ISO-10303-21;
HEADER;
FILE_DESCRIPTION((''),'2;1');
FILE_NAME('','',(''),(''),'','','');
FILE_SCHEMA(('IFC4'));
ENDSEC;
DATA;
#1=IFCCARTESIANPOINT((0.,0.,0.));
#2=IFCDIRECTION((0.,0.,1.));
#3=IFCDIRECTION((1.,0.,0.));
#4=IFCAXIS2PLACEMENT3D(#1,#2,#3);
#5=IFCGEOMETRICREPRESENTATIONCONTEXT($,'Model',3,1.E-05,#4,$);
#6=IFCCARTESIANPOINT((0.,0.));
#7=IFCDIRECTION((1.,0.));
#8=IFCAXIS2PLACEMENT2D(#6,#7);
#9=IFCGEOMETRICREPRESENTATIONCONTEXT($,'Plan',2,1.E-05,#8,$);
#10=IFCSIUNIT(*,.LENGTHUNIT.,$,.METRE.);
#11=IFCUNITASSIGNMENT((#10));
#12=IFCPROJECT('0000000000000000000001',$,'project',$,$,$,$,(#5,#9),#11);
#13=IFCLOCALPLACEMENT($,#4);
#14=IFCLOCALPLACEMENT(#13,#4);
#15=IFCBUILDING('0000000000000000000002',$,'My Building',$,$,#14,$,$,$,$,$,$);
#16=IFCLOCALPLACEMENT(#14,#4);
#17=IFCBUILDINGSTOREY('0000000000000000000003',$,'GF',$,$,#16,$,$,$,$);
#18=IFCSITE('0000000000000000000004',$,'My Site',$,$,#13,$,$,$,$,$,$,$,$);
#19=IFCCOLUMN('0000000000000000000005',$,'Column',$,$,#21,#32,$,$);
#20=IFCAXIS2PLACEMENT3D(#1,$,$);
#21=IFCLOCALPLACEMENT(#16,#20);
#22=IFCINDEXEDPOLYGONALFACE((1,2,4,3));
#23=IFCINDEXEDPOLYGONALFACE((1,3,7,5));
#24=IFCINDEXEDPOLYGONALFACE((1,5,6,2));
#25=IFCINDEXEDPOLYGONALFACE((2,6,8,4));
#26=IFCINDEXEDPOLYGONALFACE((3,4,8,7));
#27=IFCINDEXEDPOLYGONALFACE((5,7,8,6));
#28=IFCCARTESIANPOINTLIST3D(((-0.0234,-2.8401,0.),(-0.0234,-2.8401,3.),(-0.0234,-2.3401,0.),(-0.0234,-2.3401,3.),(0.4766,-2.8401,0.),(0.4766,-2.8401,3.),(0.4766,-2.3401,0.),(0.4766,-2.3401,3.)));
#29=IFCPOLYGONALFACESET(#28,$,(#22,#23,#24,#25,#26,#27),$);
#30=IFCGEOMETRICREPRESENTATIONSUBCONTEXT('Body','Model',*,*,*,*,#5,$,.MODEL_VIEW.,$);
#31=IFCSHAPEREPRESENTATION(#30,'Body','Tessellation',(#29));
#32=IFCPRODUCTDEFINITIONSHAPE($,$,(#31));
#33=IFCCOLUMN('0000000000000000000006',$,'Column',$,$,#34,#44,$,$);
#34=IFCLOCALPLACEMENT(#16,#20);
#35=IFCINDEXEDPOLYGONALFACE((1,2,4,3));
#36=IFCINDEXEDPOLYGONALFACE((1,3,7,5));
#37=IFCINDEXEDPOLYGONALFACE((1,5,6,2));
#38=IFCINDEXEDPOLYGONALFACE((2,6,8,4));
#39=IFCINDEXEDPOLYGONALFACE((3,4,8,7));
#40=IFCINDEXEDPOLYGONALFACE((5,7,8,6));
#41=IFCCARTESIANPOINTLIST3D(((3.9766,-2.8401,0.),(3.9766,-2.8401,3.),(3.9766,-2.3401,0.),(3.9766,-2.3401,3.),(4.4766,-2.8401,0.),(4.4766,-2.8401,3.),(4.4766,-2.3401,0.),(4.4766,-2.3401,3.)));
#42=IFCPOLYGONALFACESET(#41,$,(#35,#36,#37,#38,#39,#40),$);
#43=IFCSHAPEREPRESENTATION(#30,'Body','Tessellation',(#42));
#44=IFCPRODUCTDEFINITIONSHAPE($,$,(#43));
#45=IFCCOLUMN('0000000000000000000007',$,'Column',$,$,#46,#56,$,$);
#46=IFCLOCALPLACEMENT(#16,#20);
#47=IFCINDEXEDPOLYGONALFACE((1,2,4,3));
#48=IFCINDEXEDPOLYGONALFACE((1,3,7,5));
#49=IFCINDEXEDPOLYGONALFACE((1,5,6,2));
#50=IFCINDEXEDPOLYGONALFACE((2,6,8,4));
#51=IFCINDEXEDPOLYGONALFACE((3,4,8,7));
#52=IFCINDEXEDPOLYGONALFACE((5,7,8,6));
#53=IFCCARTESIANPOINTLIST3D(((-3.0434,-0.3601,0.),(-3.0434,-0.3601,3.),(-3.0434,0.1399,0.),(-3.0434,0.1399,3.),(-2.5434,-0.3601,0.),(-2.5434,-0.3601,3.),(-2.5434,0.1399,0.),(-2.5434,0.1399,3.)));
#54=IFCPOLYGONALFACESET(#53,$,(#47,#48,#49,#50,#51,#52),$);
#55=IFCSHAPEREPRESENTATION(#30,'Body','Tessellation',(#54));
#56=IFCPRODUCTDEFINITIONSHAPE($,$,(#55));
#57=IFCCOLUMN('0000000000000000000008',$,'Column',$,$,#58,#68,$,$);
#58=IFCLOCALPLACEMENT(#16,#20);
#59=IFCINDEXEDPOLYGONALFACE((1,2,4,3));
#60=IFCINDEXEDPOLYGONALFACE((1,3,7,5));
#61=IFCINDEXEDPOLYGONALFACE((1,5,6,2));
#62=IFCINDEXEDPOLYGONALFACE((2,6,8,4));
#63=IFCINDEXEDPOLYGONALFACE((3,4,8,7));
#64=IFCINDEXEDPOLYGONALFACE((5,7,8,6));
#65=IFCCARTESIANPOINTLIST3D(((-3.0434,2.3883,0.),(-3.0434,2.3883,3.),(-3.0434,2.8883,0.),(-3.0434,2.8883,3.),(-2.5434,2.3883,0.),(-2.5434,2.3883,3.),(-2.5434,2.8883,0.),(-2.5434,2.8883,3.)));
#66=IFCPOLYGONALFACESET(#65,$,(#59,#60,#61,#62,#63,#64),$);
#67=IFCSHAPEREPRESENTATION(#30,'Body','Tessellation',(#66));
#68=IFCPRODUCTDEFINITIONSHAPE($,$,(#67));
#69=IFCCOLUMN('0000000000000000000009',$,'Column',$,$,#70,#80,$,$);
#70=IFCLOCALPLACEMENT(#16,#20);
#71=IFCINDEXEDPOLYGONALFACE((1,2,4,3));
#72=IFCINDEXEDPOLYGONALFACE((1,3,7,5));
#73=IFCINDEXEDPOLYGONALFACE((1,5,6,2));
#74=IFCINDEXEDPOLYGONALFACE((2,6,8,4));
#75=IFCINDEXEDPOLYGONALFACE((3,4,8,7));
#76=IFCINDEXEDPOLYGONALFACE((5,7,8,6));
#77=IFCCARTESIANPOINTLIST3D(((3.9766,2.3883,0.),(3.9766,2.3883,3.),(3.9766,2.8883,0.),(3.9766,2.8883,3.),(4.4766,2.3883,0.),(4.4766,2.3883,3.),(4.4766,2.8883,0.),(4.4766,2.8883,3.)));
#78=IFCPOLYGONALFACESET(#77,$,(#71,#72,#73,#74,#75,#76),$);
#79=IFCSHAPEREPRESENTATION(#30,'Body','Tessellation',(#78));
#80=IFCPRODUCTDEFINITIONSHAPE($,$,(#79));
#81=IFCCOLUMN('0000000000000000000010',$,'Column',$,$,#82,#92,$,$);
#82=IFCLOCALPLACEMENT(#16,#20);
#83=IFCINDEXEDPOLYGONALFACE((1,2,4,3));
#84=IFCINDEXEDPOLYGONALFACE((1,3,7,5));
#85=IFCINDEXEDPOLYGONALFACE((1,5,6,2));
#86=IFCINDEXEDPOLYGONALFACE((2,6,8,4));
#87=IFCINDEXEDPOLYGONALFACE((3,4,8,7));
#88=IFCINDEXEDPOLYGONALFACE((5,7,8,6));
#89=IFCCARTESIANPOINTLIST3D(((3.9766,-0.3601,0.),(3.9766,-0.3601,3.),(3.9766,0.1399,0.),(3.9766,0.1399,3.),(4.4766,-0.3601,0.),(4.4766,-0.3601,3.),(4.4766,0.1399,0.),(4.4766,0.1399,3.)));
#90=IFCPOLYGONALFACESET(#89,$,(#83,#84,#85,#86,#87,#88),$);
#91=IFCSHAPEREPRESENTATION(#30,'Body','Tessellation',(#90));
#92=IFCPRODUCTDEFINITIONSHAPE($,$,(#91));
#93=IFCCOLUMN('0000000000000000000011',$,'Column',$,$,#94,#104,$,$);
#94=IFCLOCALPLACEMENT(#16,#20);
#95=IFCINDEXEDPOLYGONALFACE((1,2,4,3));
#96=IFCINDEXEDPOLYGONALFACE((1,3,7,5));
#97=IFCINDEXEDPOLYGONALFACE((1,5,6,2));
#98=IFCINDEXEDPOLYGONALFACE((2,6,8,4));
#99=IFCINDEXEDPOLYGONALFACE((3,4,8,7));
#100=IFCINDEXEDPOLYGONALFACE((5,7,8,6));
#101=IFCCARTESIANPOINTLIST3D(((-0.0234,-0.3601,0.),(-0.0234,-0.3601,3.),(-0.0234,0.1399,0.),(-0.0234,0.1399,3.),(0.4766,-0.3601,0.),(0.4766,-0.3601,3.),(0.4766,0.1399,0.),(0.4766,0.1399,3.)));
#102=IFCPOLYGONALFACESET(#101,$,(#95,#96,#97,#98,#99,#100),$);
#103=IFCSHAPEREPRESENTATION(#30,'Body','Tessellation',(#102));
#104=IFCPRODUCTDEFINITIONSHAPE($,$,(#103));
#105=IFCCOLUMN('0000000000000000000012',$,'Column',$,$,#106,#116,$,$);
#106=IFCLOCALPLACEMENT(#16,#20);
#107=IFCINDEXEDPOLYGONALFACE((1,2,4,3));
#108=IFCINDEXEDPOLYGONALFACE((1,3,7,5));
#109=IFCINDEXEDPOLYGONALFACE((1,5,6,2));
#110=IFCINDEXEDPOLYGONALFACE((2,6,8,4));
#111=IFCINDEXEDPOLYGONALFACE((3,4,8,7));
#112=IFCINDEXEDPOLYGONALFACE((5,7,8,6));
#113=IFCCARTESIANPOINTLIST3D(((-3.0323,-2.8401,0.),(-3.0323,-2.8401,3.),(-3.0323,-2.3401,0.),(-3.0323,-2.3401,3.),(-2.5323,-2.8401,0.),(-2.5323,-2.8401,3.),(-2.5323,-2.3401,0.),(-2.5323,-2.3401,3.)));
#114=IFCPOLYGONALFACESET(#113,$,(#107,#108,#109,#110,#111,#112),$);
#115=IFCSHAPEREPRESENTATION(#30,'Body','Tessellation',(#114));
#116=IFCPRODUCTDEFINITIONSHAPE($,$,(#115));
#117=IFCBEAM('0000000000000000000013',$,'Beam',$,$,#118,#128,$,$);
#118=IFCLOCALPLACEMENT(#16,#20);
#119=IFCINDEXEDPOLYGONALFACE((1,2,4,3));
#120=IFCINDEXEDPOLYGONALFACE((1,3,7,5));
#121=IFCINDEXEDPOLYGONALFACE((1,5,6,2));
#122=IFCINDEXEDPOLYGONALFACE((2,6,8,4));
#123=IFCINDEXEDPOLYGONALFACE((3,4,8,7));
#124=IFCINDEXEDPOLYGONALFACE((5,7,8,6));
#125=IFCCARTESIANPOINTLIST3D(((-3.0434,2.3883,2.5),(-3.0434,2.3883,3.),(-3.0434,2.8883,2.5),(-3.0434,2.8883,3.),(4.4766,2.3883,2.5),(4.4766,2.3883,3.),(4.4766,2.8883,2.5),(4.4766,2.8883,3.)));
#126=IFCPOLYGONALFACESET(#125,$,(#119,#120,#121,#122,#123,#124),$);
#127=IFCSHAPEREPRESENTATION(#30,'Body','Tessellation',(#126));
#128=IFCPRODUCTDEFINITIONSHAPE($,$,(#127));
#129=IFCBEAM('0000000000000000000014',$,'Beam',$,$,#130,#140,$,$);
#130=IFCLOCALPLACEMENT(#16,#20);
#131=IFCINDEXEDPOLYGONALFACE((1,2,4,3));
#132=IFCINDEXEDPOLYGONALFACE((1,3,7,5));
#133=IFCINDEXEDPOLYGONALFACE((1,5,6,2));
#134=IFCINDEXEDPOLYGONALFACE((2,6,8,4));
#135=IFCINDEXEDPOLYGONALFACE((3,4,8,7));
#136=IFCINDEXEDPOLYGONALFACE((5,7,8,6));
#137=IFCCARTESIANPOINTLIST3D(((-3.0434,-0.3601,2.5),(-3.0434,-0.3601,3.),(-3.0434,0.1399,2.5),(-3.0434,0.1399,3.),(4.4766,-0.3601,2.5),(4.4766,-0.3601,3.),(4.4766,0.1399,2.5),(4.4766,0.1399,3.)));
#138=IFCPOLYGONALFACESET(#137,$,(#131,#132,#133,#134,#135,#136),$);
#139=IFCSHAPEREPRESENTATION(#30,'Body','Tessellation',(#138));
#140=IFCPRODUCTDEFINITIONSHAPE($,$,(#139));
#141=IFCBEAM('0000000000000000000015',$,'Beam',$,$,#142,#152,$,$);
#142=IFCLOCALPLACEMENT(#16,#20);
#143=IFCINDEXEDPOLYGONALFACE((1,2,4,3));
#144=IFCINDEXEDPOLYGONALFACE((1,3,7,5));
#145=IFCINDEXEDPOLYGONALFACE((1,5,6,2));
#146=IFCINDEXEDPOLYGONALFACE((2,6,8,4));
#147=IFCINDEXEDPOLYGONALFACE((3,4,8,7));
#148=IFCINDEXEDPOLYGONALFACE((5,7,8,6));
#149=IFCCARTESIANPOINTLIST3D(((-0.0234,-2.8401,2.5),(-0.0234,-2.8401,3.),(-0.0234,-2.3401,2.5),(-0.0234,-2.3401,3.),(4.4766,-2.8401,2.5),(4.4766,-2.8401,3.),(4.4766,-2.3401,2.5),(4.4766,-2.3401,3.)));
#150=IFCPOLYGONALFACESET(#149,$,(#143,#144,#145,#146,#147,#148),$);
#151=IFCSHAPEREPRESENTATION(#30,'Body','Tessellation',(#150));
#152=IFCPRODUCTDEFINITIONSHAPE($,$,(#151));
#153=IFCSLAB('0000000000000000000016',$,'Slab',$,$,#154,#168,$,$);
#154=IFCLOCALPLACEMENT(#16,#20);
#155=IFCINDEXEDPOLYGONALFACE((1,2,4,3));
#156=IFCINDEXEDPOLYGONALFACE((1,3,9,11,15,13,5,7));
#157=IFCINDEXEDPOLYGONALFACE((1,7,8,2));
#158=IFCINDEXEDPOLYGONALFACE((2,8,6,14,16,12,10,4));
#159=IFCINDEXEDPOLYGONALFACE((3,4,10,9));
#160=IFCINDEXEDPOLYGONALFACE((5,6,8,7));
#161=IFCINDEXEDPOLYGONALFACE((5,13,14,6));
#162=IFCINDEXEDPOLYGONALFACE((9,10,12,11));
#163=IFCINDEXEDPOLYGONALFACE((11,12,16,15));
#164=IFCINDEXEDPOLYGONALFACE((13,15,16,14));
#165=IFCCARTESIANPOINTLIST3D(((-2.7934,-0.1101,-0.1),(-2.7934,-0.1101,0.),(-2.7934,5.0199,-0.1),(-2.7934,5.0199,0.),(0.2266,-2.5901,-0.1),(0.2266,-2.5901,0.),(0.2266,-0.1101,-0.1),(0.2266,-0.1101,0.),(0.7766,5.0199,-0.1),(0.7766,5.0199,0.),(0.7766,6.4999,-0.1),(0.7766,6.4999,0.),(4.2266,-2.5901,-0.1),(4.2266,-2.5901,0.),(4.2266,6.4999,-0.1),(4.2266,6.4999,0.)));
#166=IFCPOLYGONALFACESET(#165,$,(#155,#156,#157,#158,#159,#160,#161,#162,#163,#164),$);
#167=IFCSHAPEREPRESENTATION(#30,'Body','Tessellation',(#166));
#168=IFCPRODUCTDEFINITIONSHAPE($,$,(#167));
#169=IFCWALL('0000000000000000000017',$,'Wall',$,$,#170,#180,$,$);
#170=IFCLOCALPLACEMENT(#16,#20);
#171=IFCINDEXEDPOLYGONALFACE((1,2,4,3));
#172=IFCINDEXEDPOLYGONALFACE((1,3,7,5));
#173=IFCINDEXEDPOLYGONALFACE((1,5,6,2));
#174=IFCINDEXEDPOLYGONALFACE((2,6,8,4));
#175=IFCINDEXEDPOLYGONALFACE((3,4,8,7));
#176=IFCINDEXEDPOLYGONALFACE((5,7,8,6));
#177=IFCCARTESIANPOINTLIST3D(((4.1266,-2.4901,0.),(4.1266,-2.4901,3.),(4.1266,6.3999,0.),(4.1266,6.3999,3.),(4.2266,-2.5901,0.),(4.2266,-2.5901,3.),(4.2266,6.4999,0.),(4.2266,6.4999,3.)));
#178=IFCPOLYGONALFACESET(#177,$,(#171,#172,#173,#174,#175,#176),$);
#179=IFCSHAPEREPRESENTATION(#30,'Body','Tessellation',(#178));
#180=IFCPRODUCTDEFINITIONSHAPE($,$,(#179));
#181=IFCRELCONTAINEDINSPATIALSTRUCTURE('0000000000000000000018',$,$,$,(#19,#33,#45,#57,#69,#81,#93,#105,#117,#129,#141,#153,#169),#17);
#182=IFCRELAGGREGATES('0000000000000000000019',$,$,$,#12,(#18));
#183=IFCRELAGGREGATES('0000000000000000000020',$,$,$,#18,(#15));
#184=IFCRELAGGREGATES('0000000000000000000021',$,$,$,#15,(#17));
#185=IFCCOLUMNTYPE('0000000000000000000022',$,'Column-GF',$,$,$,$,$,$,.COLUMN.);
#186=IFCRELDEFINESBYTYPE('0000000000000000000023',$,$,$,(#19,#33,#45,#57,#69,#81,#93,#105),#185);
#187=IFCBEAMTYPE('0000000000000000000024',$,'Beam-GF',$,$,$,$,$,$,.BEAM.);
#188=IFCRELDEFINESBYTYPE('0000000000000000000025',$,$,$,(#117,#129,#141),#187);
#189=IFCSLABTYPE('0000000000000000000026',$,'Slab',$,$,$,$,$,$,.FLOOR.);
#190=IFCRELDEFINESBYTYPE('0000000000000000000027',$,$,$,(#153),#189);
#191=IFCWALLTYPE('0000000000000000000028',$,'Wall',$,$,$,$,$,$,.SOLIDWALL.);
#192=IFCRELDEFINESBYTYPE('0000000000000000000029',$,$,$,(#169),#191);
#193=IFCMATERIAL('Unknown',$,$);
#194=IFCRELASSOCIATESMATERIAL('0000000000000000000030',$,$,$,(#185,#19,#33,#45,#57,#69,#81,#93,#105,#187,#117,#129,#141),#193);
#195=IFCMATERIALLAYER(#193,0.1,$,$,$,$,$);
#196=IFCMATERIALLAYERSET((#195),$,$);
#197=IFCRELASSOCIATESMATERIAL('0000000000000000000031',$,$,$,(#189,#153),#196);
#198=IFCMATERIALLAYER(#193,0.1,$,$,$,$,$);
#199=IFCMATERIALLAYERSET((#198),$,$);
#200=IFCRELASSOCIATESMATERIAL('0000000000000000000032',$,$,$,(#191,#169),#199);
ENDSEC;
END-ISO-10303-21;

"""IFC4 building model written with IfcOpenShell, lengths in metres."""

from ifc_helpers import new_model, si_unit, frame, origin_with_axes, origin_2d_with_axis, place, context, subcontext, project, spatial, line, indexed_curve, rectangle, outline, extrude, material, layer, layer_set, layer_usage, material_profile, profile_set, profile_usage, type_object, element, save


model = new_model("IFC4")

# Units and contexts
model_context = context("Model", 3, precision=1e-05, world=origin_with_axes())
plan_context = context("Plan", 2, precision=1e-05, world=origin_2d_with_axis())
body_context_1 = subcontext(model_context, "Body", "Model", "MODEL_VIEW")
ifc_project = project(units=[si_unit("LENGTHUNIT", "METRE")], contexts=[model_context, plan_context])

# Site, building, storey
site_placement = place(None, origin_with_axes())
site = spatial("IfcSite", under=ifc_project, at=site_placement, Name="My Site")
building_placement = place(site_placement, origin_with_axes())
building = spatial("IfcBuilding", under=site, at=building_placement, Name="My Building")
storey_placement = place(building_placement, origin_with_axes())
storey = spatial("IfcBuildingStorey", under=building, at=storey_placement, Name="GF")

# Columns
ifc_material = material(Name="Unknown")
ifc_material_profile_1 = material_profile(ifc_material, rectangle(XDim=0.5, YDim=0.5))
ifc_profile_set_1 = profile_set([ifc_material_profile_1])
ifc_profile_usage_1 = profile_usage(ifc_profile_set_1, cardinal=5)
column_type = type_object("IfcColumnType", Name="Column-GF", PredefinedType="COLUMN", material=ifc_profile_set_1)
column_1_placement = place(storey_placement, frame((0.2266, -2.5901, 0.0), z_axis=(0.0, 0.0, 1.0), x_axis=(1.0, 0.0, 0.0)))
element("IfcColumn", 1, at=column_1_placement, inside=storey, type_object=column_type, material=ifc_profile_usage_1, Name="Column", context=body_context_1, shape_type="SweptSolid", body=[
    extrude(rectangle(XDim=0.5, YDim=0.5), origin_with_axes(), (0.0, 0.0, 1.0), 3.0),
])
ifc_profile_usage_2 = profile_usage(ifc_profile_set_1, cardinal=5)
column_2_placement = place(storey_placement, frame((4.2266, -2.5901, 0.0), z_axis=(0.0, 0.0, 1.0), x_axis=(1.0, 0.0, 0.0)))
element("IfcColumn", 2, at=column_2_placement, inside=storey, type_object=column_type, material=ifc_profile_usage_2, Name="Column", context=body_context_1, shape_type="SweptSolid", body=[
    extrude(rectangle(XDim=0.5, YDim=0.5), origin_with_axes(), (0.0, 0.0, 1.0), 3.0),
])
ifc_profile_usage_3 = profile_usage(ifc_profile_set_1, cardinal=5)
column_3_placement = place(storey_placement, frame((-2.7934, -0.1101, 0.0), z_axis=(0.0, 0.0, 1.0), x_axis=(1.0, 0.0, 0.0)))
element("IfcColumn", 3, at=column_3_placement, inside=storey, type_object=column_type, material=ifc_profile_usage_3, Name="Column", context=body_context_1, shape_type="SweptSolid", body=[
    extrude(rectangle(XDim=0.5, YDim=0.5), origin_with_axes(), (0.0, 0.0, 1.0), 3.0),
])
ifc_profile_usage_4 = profile_usage(ifc_profile_set_1, cardinal=5)
column_4_placement = place(storey_placement, frame((-2.7934, 2.6383, 0.0), z_axis=(0.0, 0.0, 1.0), x_axis=(1.0, 0.0, 0.0)))
element("IfcColumn", 4, at=column_4_placement, inside=storey, type_object=column_type, material=ifc_profile_usage_4, Name="Column", context=body_context_1, shape_type="SweptSolid", body=[
    extrude(rectangle(XDim=0.5, YDim=0.5), origin_with_axes(), (0.0, 0.0, 1.0), 3.0),
])
ifc_profile_usage_5 = profile_usage(ifc_profile_set_1, cardinal=5)
column_5_placement = place(storey_placement, frame((4.2266, 2.6383, 0.0), z_axis=(0.0, 0.0, 1.0), x_axis=(1.0, 0.0, 0.0)))
element("IfcColumn", 5, at=column_5_placement, inside=storey, type_object=column_type, material=ifc_profile_usage_5, Name="Column", context=body_context_1, shape_type="SweptSolid", body=[
    extrude(rectangle(XDim=0.5, YDim=0.5), origin_with_axes(), (0.0, 0.0, 1.0), 3.0),
])
ifc_profile_usage_6 = profile_usage(ifc_profile_set_1, cardinal=5)
column_6_placement = place(storey_placement, frame((4.2266, -0.1101, 0.0), z_axis=(0.0, 0.0, 1.0), x_axis=(1.0, 0.0, 0.0)))
element("IfcColumn", 6, at=column_6_placement, inside=storey, type_object=column_type, material=ifc_profile_usage_6, Name="Column", context=body_context_1, shape_type="SweptSolid", body=[
    extrude(rectangle(XDim=0.5, YDim=0.5), origin_with_axes(), (0.0, 0.0, 1.0), 3.0),
])
ifc_profile_usage_7 = profile_usage(ifc_profile_set_1, cardinal=5)
column_7_placement = place(storey_placement, frame((0.2266, -0.1101, 0.0), z_axis=(0.0, 0.0, 1.0), x_axis=(1.0, 0.0, 0.0)))
element("IfcColumn", 7, at=column_7_placement, inside=storey, type_object=column_type, material=ifc_profile_usage_7, Name="Column", context=body_context_1, shape_type="SweptSolid", body=[
    extrude(rectangle(XDim=0.5, YDim=0.5), origin_with_axes(), (0.0, 0.0, 1.0), 3.0),
])
ifc_profile_usage_8 = profile_usage(ifc_profile_set_1, cardinal=5)
column_8_placement = place(storey_placement, frame((-2.7823, -2.5901, 0.0), z_axis=(0.0, 0.0, 1.0), x_axis=(1.0, 0.0, 0.0)))
element("IfcColumn", 8, at=column_8_placement, inside=storey, type_object=column_type, material=ifc_profile_usage_8, Name="Column", context=body_context_1, shape_type="SweptSolid", body=[
    extrude(rectangle(XDim=0.5, YDim=0.5), origin_with_axes(), (0.0, 0.0, 1.0), 3.0),
])

# Beams
ifc_material_profile_2 = material_profile(ifc_material, rectangle(XDim=0.5, YDim=0.5))
ifc_profile_set_2 = profile_set([ifc_material_profile_2])
ifc_profile_usage_9 = profile_usage(ifc_profile_set_2, cardinal=7)
beam_type = type_object("IfcBeamType", Name="Beam-GF", PredefinedType="BEAM", material=ifc_profile_set_2)
beam_1_placement = place(storey_placement, frame((4.4766, 2.3883, 3.0), z_axis=(-1.0, 0.0, 0.0), x_axis=(0.0, -1.0, 0.0)))
element("IfcBeam", 9, at=beam_1_placement, inside=storey, type_object=beam_type, material=ifc_profile_usage_9, Name="Beam", context=body_context_1, shape_type="SweptSolid", body=[
    extrude(rectangle(XDim=0.5, YDim=0.5), frame((-0.25, -0.25, 0.0), z_axis=(0.0, 0.0, 1.0), x_axis=(1.0, 0.0, 0.0)), (0.0, 0.0, 1.0), 7.52),
])
ifc_profile_usage_10 = profile_usage(ifc_profile_set_2, cardinal=7)
beam_2_placement = place(storey_placement, frame((4.4766, -0.3601, 3.0), z_axis=(-1.0, 0.0, 0.0), x_axis=(0.0, -1.0, 0.0)))
element("IfcBeam", 10, at=beam_2_placement, inside=storey, type_object=beam_type, material=ifc_profile_usage_10, Name="Beam", context=body_context_1, shape_type="SweptSolid", body=[
    extrude(rectangle(XDim=0.5, YDim=0.5), frame((-0.25, -0.25, 0.0), z_axis=(0.0, 0.0, 1.0), x_axis=(1.0, 0.0, 0.0)), (0.0, 0.0, 1.0), 7.52),
])
ifc_profile_usage_11 = profile_usage(ifc_profile_set_2, cardinal=7)
beam_3_placement = place(storey_placement, frame((4.4766, -2.8401, 3.0), z_axis=(-1.0, -0.000001, 0.000001), x_axis=(0.000001, -1.0, 0.0)))
element("IfcBeam", 11, at=beam_3_placement, inside=storey, type_object=beam_type, material=ifc_profile_usage_11, Name="Beam", context=body_context_1, shape_type="SweptSolid", body=[
    extrude(rectangle(XDim=0.5, YDim=0.5), frame((-0.25, -0.25, 0.0), z_axis=(0.0, 0.0, 1.0), x_axis=(1.0, 0.0, 0.0)), (0.0, 0.0, 1.0), 4.5),
])

# Slab
ifc_layer_1 = layer(ifc_material, 0.1)
ifc_layer_set_1 = layer_set([ifc_layer_1])
ifc_layer_usage_1 = layer_usage(ifc_layer_set_1, "AXIS3", "POSITIVE", -0.1)
slab_type_1 = type_object("IfcSlabType", Name="Slab", PredefinedType="FLOOR", material=ifc_layer_set_1)
slab_1_placement = place(storey_placement, frame((4.2266, -2.5901, 0.0), z_axis=(0.0, 0.0, 1.0), x_axis=(1.0, 0.0, 0.0)))
element("IfcSlab", 12, at=slab_1_placement, inside=storey, type_object=slab_type_1, material=ifc_layer_usage_1, Name="Slab", context=body_context_1, shape_type="SweptSolid", body=[
    extrude(outline(indexed_curve([(0.0, 0.0), (0.0, 9.09), (-3.45, 9.09), (-3.45, 7.61), (-7.02, 7.61), (-7.02, 2.48), (-4.0, 2.48), (-4.0, 0.0), (0.0, 0.0)])), frame((0.0, 0.0, -0.1), z_axis=(0.0, 0.0, 1.0), x_axis=(1.0, 0.0, 0.0)), (0.0, 0.0, 1.0), 0.1),
])

# Shared definitions
ifc_layer_2 = layer(ifc_material, 0.1)
ifc_layer_set_2 = layer_set([ifc_layer_2])
wall_type = type_object("IfcWallType", Name="Wall", PredefinedType="SOLIDWALL", material=ifc_layer_set_2)

# Wall
ifc_layer_usage_2 = layer_usage(ifc_layer_set_2, "AXIS2", "POSITIVE", 0.0)
wall_1_placement = place(storey_placement, frame((4.2266, -2.5901, 0.0), z_axis=(0.0, 0.0, 1.0), x_axis=(0.0, 1.0, 0.0)))
element("IfcWall", 13, at=wall_1_placement, inside=storey, type_object=wall_type, material=ifc_layer_usage_2, Name="Wall", context=body_context_1, shape_type="SweptSolid", body=[
    extrude(outline(indexed_curve([(0.0, 0.0), (0.1, 0.1), (8.99, 0.1), (9.09, 0.0)], segments=[line(1, 2, 3, 4, 1)])), origin_with_axes(), (0.0, 0.0, 1.0), 3.0),
])

save(model, "model.ifc")
